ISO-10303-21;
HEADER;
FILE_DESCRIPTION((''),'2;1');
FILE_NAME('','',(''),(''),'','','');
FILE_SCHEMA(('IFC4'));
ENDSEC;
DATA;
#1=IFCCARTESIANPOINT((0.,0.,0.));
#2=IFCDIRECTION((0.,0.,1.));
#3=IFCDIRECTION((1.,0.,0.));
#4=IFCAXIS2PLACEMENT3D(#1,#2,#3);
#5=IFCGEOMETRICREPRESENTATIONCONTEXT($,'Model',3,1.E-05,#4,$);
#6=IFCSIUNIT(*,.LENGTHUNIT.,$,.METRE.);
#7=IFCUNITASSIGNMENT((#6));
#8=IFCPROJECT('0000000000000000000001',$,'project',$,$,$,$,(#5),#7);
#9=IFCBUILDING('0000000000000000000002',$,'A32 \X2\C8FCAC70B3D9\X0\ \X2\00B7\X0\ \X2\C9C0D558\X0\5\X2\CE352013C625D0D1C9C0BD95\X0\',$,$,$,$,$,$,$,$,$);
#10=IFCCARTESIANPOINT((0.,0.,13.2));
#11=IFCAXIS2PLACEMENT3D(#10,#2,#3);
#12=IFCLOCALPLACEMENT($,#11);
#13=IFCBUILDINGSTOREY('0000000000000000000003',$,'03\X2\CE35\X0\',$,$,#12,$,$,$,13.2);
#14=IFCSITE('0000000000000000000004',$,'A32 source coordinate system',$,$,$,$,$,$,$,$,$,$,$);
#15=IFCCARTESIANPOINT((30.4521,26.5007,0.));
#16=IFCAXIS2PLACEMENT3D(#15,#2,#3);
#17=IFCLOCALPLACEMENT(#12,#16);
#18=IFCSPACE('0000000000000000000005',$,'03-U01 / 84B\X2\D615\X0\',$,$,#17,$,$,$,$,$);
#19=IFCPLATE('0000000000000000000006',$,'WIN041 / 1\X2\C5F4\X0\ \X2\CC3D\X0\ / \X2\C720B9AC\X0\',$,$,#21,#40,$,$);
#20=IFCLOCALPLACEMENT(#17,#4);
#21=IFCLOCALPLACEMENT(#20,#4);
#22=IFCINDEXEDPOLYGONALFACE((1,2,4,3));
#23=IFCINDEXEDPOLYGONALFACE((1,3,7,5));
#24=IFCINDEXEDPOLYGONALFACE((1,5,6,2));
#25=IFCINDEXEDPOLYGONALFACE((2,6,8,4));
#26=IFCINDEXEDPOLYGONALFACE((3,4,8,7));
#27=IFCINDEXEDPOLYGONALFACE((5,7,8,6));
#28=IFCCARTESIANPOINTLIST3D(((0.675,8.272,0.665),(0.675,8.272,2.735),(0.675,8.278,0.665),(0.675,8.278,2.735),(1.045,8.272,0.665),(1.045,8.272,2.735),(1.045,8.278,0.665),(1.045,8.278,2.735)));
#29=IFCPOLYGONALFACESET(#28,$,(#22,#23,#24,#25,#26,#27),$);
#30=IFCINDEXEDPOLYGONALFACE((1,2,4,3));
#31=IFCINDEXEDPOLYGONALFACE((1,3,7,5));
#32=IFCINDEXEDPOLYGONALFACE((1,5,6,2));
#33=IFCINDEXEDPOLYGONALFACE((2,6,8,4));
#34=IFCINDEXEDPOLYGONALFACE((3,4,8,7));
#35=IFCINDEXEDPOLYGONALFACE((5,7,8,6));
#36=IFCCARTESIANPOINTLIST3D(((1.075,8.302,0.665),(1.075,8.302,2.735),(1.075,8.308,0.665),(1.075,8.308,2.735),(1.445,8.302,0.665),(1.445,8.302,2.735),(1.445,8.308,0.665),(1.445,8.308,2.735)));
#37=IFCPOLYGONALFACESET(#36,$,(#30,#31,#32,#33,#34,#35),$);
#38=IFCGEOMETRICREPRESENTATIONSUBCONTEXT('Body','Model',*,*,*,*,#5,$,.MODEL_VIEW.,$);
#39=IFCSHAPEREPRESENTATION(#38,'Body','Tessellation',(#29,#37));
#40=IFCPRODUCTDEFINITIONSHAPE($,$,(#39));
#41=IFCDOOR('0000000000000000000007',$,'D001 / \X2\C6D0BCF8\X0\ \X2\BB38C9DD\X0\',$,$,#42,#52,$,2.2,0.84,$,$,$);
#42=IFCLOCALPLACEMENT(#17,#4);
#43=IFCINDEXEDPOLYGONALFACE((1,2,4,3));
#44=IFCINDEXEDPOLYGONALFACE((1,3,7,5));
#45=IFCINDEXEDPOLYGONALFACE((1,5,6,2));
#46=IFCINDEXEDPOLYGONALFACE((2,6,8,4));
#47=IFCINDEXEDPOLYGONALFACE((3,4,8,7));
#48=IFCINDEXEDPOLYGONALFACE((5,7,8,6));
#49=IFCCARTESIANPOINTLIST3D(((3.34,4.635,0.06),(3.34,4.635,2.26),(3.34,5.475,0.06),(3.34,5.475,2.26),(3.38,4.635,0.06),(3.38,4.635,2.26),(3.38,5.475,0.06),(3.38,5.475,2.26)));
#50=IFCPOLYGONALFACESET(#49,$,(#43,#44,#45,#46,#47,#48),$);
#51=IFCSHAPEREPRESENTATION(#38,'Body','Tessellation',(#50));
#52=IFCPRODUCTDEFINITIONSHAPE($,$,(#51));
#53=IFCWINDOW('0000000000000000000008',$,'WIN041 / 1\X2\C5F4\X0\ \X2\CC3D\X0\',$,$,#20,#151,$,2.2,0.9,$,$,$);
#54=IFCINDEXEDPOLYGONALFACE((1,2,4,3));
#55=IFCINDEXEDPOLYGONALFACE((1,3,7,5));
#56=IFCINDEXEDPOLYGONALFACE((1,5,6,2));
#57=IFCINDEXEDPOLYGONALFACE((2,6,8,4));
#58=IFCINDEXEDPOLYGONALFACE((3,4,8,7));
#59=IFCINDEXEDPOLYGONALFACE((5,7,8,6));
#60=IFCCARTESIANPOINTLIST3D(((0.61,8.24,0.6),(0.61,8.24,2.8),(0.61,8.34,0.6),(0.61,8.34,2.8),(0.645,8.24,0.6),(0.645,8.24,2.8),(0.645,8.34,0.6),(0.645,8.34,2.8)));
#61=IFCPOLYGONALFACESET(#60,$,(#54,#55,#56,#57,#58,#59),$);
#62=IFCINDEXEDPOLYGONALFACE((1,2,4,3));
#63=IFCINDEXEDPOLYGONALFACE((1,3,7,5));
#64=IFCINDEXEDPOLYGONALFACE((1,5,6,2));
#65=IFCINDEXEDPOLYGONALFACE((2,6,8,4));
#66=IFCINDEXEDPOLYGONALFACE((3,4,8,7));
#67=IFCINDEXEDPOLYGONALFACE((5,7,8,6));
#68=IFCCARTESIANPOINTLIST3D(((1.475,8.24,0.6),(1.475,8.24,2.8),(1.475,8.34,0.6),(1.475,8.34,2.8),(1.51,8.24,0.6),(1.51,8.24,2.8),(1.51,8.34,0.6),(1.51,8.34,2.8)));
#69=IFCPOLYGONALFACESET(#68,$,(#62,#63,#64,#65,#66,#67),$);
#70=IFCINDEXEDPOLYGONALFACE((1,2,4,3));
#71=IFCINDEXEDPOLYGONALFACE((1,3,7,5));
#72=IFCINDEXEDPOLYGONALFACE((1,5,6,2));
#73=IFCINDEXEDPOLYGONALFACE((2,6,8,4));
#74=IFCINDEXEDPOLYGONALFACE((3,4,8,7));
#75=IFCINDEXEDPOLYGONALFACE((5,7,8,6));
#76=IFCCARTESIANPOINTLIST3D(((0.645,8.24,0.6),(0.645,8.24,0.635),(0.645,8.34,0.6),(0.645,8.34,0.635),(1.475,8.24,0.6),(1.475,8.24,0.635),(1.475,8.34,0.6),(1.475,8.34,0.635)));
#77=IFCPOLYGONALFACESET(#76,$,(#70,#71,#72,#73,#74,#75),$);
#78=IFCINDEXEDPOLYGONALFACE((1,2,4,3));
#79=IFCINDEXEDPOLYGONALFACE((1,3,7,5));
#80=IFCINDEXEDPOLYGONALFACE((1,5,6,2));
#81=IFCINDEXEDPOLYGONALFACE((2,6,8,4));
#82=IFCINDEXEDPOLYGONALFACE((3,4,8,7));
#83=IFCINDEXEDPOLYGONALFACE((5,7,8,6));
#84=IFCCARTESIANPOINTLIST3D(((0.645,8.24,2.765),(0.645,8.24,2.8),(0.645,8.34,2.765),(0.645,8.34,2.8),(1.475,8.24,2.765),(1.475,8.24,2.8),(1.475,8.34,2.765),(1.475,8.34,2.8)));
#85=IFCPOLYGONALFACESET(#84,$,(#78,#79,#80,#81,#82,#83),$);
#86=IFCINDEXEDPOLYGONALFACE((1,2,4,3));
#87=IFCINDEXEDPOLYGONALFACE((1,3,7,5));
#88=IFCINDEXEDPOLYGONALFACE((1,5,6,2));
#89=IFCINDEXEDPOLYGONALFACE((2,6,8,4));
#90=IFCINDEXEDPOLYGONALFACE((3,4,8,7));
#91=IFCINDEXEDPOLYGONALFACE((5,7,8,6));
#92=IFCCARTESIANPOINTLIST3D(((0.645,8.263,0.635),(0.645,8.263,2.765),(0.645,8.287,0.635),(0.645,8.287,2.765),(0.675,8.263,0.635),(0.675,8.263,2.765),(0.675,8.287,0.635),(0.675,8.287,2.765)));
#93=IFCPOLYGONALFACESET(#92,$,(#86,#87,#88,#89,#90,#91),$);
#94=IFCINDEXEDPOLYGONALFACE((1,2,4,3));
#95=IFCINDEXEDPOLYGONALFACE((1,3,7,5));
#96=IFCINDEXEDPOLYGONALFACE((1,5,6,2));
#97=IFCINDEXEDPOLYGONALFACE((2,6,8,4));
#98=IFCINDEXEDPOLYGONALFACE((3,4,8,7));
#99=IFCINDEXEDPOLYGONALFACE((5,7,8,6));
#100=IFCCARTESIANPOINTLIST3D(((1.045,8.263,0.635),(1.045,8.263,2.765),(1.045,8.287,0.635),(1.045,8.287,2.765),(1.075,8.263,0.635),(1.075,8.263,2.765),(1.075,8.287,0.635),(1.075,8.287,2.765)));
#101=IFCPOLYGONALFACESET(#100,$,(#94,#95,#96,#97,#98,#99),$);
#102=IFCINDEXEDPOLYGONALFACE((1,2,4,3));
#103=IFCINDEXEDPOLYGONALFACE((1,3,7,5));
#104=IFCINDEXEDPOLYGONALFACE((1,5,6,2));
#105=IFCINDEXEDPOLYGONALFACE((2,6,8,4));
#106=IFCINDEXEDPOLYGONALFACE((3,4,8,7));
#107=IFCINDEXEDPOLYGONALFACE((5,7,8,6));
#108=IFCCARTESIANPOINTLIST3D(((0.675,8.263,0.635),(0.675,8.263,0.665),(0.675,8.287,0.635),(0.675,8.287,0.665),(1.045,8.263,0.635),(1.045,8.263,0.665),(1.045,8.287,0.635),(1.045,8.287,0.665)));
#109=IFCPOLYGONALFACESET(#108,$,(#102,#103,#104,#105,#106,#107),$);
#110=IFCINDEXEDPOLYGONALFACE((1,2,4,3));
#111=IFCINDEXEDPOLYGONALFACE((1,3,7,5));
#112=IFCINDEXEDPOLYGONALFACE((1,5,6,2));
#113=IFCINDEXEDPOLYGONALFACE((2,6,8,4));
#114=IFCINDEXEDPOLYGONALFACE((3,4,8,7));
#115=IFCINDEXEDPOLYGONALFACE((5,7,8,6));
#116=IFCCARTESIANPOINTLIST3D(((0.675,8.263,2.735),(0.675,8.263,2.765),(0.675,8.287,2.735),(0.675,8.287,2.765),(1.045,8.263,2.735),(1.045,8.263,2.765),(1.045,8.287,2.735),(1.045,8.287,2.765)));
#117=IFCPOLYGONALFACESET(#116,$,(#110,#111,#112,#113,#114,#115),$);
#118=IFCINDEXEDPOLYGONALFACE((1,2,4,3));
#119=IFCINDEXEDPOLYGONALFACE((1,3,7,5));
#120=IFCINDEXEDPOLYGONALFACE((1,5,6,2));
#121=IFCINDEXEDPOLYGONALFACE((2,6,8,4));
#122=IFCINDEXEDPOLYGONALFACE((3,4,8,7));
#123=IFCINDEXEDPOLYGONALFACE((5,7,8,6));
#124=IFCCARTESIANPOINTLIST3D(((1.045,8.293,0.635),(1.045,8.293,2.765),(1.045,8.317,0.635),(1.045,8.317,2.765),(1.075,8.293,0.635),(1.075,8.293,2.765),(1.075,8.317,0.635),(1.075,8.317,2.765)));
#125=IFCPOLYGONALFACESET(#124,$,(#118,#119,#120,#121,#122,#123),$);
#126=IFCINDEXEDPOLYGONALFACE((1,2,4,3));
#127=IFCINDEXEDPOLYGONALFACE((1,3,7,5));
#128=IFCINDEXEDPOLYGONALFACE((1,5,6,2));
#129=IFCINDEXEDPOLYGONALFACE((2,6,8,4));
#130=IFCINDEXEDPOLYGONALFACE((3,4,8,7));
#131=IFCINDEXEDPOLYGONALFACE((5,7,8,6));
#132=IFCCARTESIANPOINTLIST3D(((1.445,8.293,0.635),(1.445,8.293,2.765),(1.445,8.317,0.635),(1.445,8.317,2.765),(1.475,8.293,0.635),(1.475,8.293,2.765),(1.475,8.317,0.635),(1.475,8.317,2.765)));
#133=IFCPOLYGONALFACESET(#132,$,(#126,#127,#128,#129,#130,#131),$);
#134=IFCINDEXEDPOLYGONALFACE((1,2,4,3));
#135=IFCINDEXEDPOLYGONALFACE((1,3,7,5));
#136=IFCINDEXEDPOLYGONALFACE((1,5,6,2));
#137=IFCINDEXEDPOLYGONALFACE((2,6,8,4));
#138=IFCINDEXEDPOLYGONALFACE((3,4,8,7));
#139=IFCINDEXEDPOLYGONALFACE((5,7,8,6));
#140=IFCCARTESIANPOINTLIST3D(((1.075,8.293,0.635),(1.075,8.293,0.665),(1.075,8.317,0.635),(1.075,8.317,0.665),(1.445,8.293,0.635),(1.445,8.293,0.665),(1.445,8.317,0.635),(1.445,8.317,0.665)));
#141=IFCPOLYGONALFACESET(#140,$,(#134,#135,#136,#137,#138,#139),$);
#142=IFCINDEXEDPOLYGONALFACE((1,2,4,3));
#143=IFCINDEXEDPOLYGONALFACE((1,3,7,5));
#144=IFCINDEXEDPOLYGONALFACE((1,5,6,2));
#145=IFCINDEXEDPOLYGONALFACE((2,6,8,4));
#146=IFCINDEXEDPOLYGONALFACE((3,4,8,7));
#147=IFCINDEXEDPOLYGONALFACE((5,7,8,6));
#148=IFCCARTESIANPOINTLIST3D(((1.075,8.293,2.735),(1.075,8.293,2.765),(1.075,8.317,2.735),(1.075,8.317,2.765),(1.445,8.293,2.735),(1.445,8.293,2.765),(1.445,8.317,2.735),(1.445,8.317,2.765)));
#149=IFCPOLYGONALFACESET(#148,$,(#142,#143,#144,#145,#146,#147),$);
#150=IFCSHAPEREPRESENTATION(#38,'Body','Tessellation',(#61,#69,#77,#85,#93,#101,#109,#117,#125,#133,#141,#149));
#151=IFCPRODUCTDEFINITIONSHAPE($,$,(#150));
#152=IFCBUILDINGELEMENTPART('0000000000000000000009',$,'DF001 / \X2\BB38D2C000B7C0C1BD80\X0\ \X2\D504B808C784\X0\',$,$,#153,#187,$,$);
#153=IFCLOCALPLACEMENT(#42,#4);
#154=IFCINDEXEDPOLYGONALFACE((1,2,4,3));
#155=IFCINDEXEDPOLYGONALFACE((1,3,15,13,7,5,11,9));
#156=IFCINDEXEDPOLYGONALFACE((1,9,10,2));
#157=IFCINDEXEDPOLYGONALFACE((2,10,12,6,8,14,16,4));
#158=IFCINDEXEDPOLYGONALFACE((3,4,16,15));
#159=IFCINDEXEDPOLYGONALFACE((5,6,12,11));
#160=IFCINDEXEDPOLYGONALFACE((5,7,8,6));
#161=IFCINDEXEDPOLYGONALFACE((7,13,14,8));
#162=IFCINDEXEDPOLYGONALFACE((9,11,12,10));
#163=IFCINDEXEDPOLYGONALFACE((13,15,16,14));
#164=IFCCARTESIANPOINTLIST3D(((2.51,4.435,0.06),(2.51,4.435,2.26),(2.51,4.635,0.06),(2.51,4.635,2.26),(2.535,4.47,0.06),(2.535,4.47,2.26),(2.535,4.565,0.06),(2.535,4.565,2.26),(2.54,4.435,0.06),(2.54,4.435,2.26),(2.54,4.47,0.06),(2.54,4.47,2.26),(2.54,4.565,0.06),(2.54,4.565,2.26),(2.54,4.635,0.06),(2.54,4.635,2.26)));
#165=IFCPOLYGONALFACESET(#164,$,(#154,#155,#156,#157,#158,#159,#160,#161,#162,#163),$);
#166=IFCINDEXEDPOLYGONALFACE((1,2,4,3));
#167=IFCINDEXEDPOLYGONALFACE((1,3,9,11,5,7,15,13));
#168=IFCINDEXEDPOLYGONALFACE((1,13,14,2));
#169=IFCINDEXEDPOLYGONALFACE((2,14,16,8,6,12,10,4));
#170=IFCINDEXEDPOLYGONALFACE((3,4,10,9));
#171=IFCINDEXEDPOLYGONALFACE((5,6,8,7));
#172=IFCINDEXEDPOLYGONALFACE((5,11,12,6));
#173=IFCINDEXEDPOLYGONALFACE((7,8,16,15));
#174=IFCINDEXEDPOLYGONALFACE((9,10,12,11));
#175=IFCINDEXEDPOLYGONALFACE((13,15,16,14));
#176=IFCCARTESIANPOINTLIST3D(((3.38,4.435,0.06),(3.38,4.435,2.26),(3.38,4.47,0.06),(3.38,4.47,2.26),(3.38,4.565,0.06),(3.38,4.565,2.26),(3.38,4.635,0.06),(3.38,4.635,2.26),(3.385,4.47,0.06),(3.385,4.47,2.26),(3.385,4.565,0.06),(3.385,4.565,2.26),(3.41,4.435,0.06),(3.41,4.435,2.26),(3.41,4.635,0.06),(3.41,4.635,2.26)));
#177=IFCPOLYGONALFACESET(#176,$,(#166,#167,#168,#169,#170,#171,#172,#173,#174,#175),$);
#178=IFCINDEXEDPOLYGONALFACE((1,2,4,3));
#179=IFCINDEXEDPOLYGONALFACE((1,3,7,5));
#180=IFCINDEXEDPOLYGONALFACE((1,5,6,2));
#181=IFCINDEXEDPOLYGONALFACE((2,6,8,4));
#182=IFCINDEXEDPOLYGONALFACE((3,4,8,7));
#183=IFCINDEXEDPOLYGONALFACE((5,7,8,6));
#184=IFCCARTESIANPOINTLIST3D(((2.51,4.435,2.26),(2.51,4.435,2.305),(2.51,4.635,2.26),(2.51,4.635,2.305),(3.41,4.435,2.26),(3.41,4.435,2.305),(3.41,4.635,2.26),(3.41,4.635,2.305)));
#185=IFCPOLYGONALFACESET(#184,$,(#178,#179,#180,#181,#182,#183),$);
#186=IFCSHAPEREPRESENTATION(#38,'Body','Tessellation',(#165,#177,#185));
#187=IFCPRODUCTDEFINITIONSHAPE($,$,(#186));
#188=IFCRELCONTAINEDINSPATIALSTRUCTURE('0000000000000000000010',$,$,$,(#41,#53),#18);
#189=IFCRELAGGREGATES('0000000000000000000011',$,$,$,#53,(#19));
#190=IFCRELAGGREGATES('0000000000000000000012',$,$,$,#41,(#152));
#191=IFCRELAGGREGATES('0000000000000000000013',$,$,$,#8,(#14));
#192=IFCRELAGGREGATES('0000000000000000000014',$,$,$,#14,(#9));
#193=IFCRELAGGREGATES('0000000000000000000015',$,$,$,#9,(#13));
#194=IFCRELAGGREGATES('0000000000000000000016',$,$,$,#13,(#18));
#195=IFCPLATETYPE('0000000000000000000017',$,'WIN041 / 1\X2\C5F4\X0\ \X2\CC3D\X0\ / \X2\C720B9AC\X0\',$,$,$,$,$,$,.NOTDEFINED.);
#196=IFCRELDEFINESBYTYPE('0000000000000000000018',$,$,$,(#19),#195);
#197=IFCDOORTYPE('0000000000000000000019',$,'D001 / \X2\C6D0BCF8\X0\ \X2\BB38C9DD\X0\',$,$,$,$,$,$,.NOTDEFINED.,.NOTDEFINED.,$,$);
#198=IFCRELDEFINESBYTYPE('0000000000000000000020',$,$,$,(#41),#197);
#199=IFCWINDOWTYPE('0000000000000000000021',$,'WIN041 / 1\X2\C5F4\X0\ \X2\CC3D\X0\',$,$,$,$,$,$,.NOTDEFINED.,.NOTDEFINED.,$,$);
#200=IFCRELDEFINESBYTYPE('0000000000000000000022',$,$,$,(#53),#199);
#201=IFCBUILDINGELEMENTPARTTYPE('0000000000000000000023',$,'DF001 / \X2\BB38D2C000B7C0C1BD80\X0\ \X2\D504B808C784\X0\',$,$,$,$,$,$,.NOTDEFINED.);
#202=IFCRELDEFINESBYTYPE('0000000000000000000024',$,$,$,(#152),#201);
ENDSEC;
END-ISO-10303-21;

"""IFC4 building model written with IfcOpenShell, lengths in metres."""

from ifc_helpers import new_model, si_unit, frame, origin, origin_with_axes, place, context, subcontext, project, spatial, polyline, outline, extrude, source, transform, mapped, type_object, type_shapes, element, aggregate, save


model = new_model("IFC4")

# Units and contexts
model_context = context("Model", 3, precision=1e-05, world=origin_with_axes())
body_context = subcontext(model_context, "Body", "Model", "MODEL_VIEW")
ifc_project = project(units=[si_unit("LENGTHUNIT", "METRE")], contexts=[model_context])

# Plate
storey_placement = place(None, frame((0.0, 0.0, 13.2), z_axis=(0.0, 0.0, 1.0), x_axis=(1.0, 0.0, 0.0)))
space_placement = place(storey_placement, frame((30.4521, 26.5007, 0.0), z_axis=(0.0, 0.0, 1.0), x_axis=(1.0, 0.0, 0.0)))
plate_type_1 = type_object("IfcPlateType", Name="WIN041 / 1열 창 / 유리", PredefinedType="NOTDEFINED")
shared_shape_1 = source(origin(), body_context, "Body", "SweptSolid", [
    extrude(outline(polyline([(0.675, 8.272), (0.675, 8.278), (1.045, 8.278), (1.045, 8.272), (0.675, 8.272)])), frame((0.0, 0.0, 0.665)), (0.0, 0.0, 1.0), 2.07),
    extrude(outline(polyline([(1.075, 8.302), (1.075, 8.308), (1.445, 8.308), (1.445, 8.302), (1.075, 8.302)])), frame((0.0, 0.0, 0.665)), (0.0, 0.0, 1.0), 2.07),
])
type_shapes(plate_type_1, [shared_shape_1])
window_1_placement = place(space_placement, origin_with_axes())
plate_1_placement = place(window_1_placement, origin_with_axes())
plate_1 = element("IfcPlate", 1, at=plate_1_placement, type_object=plate_type_1, Name="WIN041 / 1열 창 / 유리", context=body_context, shape_type="MappedRepresentation", body=[
    mapped(shared_shape_1, transform((0.0, 0.0, 0.0), scale=1.0)),
])

# Site, building, storey, space
site = spatial("IfcSite", under=ifc_project, Name="A32 source coordinate system")
building = spatial("IfcBuilding", under=site, Name="A32 주거동 · 지하5층–옥탑지붕")
storey = spatial("IfcBuildingStorey", under=building, at=storey_placement, Name="03층", Elevation=13.2)
space = spatial("IfcSpace", under=storey, at=space_placement, Name="03-U01 / 84B형")

# Door
door_type_1 = type_object("IfcDoorType", Name="D001 / 원본 문짝", OperationType="NOTDEFINED", PredefinedType="NOTDEFINED")
shared_shape_2 = source(origin(), body_context, "Body", "SweptSolid", [
    extrude(outline(polyline([(3.34, 5.475), (3.38, 5.475), (3.38, 4.635), (3.34, 4.635), (3.34, 5.475)])), frame((0.0, 0.0, 0.06)), (0.0, 0.0, 1.0), 2.2),
])
type_shapes(door_type_1, [shared_shape_2])
door_1_placement = place(space_placement, origin_with_axes())
door_1 = element("IfcDoor", 2, at=door_1_placement, inside=space, type_object=door_type_1, Name="D001 / 원본 문짝", OverallHeight=2.2, OverallWidth=0.84, context=body_context, shape_type="MappedRepresentation", body=[
    mapped(shared_shape_2, transform((0.0, 0.0, 0.0), scale=1.0)),
])

# Window
window_type_1 = type_object("IfcWindowType", Name="WIN041 / 1열 창", PartitioningType="NOTDEFINED", PredefinedType="NOTDEFINED")
shared_shape_3 = source(origin(), body_context, "Body", "SweptSolid", [
    extrude(outline(polyline([(0.61, 8.24), (0.61, 8.34), (0.645, 8.34), (0.645, 8.24), (0.61, 8.24)])), frame((0.0, 0.0, 0.6)), (0.0, 0.0, 1.0), 2.2),
    extrude(outline(polyline([(1.475, 8.24), (1.475, 8.34), (1.51, 8.34), (1.51, 8.24), (1.475, 8.24)])), frame((0.0, 0.0, 0.6)), (0.0, 0.0, 1.0), 2.2),
    extrude(outline(polyline([(0.645, 8.24), (0.645, 8.34), (1.475, 8.34), (1.475, 8.24), (0.645, 8.24)])), frame((0.0, 0.0, 0.6)), (0.0, 0.0, 1.0), 0.035),
    extrude(outline(polyline([(0.645, 8.24), (0.645, 8.34), (1.475, 8.34), (1.475, 8.24), (0.645, 8.24)])), frame((0.0, 0.0, 2.765)), (0.0, 0.0, 1.0), 0.035),
    extrude(outline(polyline([(0.645, 8.263), (0.645, 8.287), (0.675, 8.287), (0.675, 8.263), (0.645, 8.263)])), frame((0.0, 0.0, 0.635)), (0.0, 0.0, 1.0), 2.13),
    extrude(outline(polyline([(1.045, 8.263), (1.045, 8.287), (1.075, 8.287), (1.075, 8.263), (1.045, 8.263)])), frame((0.0, 0.0, 0.635)), (0.0, 0.0, 1.0), 2.13),
    extrude(outline(polyline([(0.675, 8.263), (0.675, 8.287), (1.045, 8.287), (1.045, 8.263), (0.675, 8.263)])), frame((0.0, 0.0, 0.635)), (0.0, 0.0, 1.0), 0.03),
    extrude(outline(polyline([(0.675, 8.263), (0.675, 8.287), (1.045, 8.287), (1.045, 8.263), (0.675, 8.263)])), frame((0.0, 0.0, 2.735)), (0.0, 0.0, 1.0), 0.03),
    extrude(outline(polyline([(1.045, 8.293), (1.045, 8.317), (1.075, 8.317), (1.075, 8.293), (1.045, 8.293)])), frame((0.0, 0.0, 0.635)), (0.0, 0.0, 1.0), 2.13),
    extrude(outline(polyline([(1.445, 8.293), (1.445, 8.317), (1.475, 8.317), (1.475, 8.293), (1.445, 8.293)])), frame((0.0, 0.0, 0.635)), (0.0, 0.0, 1.0), 2.13),
    extrude(outline(polyline([(1.075, 8.293), (1.075, 8.317), (1.445, 8.317), (1.445, 8.293), (1.075, 8.293)])), frame((0.0, 0.0, 0.635)), (0.0, 0.0, 1.0), 0.03),
    extrude(outline(polyline([(1.075, 8.293), (1.075, 8.317), (1.445, 8.317), (1.445, 8.293), (1.075, 8.293)])), frame((0.0, 0.0, 2.735)), (0.0, 0.0, 1.0), 0.03),
])
type_shapes(window_type_1, [shared_shape_3])
window_1 = element("IfcWindow", 3, at=window_1_placement, inside=space, type_object=window_type_1, Name="WIN041 / 1열 창", OverallHeight=2.2, OverallWidth=0.9, context=body_context, shape_type="MappedRepresentation", body=[
    mapped(shared_shape_3, transform((0.0, 0.0, 0.0), scale=1.0)),
])
aggregate(window_1, [plate_1])

# Building element part
building_element_part_type_1 = type_object("IfcBuildingElementPartType", Name="DF001 / 문틀·상부 프레임", PredefinedType="NOTDEFINED")
shared_shape_4 = source(origin(), body_context, "Body", "SweptSolid", [
    extrude(outline(polyline([(2.54, 4.635), (2.54, 4.565), (2.535, 4.565), (2.535, 4.47), (2.54, 4.47), (2.54, 4.435), (2.51, 4.435), (2.51, 4.635), (2.54, 4.635)])), frame((0.0, 0.0, 0.06)), (0.0, 0.0, 1.0), 2.2),
    extrude(outline(polyline([(3.41, 4.435), (3.38, 4.435), (3.38, 4.47), (3.385, 4.47), (3.385, 4.565), (3.38, 4.565), (3.38, 4.635), (3.41, 4.635), (3.41, 4.435)])), frame((0.0, 0.0, 0.06)), (0.0, 0.0, 1.0), 2.2),
    extrude(outline(polyline([(2.51, 4.435), (2.51, 4.635), (3.41, 4.635), (3.41, 4.435), (2.51, 4.435)])), frame((0.0, 0.0, 2.26)), (0.0, 0.0, 1.0), 0.045),
])
type_shapes(building_element_part_type_1, [shared_shape_4])
building_element_part_1_placement = place(door_1_placement, origin_with_axes())
building_element_part_1 = element("IfcBuildingElementPart", 4, at=building_element_part_1_placement, type_object=building_element_part_type_1, Name="DF001 / 문틀·상부 프레임", context=body_context, shape_type="MappedRepresentation", body=[
    mapped(shared_shape_4, transform((0.0, 0.0, 0.0), scale=1.0)),
])
aggregate(door_1, [building_element_part_1])

save(model, "model.ifc")
